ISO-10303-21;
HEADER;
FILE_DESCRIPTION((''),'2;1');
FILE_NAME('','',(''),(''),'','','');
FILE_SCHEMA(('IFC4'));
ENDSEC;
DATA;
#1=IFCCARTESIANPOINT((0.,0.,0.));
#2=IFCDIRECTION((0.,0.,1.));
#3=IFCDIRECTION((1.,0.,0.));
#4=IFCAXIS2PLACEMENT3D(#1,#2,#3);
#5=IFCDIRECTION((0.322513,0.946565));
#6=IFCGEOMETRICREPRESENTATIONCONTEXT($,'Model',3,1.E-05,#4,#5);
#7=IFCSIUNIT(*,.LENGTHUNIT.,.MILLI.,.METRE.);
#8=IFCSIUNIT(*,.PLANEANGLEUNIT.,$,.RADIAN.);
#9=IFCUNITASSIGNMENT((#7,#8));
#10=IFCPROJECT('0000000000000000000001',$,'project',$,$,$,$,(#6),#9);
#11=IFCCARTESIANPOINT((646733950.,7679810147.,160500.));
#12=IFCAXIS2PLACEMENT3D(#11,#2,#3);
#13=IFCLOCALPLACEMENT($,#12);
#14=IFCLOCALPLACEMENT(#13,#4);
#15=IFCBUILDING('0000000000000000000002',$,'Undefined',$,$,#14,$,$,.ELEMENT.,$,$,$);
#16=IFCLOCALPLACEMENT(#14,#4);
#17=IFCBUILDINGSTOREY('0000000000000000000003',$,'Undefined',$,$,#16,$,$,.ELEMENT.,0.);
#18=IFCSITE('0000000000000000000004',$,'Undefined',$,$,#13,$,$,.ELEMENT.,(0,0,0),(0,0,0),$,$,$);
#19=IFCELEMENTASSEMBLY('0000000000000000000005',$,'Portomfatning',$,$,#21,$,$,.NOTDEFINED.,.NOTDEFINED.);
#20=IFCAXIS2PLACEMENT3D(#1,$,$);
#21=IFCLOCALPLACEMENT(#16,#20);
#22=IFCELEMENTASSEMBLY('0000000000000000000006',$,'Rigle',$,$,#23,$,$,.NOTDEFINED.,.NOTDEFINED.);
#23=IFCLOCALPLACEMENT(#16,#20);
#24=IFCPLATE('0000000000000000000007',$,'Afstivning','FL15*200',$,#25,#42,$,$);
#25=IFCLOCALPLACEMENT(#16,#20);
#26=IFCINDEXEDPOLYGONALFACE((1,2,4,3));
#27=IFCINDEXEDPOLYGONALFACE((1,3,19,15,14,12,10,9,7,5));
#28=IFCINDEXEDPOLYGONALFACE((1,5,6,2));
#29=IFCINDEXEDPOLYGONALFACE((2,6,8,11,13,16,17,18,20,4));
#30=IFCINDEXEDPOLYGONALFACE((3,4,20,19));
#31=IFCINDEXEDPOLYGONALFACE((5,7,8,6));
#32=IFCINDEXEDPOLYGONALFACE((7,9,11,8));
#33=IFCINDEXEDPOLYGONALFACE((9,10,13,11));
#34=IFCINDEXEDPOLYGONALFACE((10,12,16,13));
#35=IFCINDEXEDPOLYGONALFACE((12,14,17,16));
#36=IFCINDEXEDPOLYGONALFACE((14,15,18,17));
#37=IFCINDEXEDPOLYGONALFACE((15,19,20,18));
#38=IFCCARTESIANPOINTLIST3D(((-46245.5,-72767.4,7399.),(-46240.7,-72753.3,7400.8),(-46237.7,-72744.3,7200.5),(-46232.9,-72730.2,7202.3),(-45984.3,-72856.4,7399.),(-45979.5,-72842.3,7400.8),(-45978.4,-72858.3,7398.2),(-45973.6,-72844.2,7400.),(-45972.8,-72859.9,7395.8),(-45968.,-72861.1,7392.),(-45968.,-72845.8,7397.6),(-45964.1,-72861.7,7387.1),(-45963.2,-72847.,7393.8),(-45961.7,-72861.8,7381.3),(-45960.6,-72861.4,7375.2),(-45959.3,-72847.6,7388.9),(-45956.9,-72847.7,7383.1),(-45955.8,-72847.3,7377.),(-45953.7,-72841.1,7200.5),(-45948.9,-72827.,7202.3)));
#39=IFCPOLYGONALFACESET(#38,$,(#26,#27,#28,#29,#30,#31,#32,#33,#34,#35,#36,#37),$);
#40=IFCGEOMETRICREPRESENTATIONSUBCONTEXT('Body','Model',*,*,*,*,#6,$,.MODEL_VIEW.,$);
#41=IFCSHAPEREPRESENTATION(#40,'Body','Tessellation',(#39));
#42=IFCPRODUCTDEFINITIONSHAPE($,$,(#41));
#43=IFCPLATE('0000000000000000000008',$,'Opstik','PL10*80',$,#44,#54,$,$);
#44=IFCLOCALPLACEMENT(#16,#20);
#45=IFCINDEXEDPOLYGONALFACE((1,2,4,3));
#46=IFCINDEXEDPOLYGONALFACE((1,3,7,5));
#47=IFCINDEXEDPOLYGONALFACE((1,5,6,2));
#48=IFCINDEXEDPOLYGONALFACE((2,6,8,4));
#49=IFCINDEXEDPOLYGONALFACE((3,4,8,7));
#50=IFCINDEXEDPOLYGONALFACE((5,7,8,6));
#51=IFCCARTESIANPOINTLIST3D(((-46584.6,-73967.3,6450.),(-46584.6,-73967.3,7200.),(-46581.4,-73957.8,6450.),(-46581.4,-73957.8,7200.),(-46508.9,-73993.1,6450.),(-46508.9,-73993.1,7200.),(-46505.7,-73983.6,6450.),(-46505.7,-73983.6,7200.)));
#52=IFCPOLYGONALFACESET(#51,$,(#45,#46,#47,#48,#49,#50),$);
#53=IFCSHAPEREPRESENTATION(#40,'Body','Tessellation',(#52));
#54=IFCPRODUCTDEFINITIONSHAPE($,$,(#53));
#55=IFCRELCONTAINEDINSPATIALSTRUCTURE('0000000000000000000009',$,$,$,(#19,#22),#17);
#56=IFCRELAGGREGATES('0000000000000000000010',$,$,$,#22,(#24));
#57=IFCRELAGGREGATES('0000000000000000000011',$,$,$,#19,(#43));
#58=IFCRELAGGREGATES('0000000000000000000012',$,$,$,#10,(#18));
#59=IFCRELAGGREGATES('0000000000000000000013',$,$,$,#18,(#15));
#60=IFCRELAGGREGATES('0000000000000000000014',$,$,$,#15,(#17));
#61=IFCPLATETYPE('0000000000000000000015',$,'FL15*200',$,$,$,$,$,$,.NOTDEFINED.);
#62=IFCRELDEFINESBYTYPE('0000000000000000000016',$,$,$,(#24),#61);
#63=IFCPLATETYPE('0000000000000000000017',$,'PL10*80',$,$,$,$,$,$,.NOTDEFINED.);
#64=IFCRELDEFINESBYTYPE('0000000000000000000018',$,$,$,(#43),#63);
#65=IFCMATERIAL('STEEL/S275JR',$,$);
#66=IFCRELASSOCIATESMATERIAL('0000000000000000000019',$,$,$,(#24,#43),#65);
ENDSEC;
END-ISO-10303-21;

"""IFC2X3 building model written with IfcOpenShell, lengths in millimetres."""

from ifc_helpers import new_model, si_unit, direction, frame, frame_2d, origin_with_axes, place, context, subcontext, project, spatial, polyline, circle_curve, parameter, trimmed, segment, composite_curve, outline, extrude, material, type_object, element, aggregate, save


model = new_model("IFC2X3")

# Units and contexts
model_context = context("Model", 3, precision=1e-05, world=origin_with_axes(), true_north=direction((0.322513, 0.946565)))
body_context = subcontext(model_context, "Body", "Model", "MODEL_VIEW")
ifc_project = project(units=[si_unit("LENGTHUNIT", "METRE", prefix="MILLI"), si_unit("PLANEANGLEUNIT", "RADIAN")], contexts=[model_context])

# Site, building, storey
site_placement = place(None, frame((646733950.0, 7679810147.0, 160500.0), z_axis=(0.0, 0.0, 1.0), x_axis=(1.0, 0.0, 0.0)))
site = spatial("IfcSite", under=ifc_project, at=site_placement, Name="Undefined", CompositionType="ELEMENT", RefLatitude=(0, 0, 0), RefLongitude=(0, 0, 0))
building_placement = place(site_placement, origin_with_axes())
building = spatial("IfcBuilding", under=site, at=building_placement, Name="Undefined", CompositionType="ELEMENT")
storey_placement = place(building_placement, origin_with_axes())
storey = spatial("IfcBuildingStorey", under=building, at=storey_placement, Name="Undefined", CompositionType="ELEMENT", Elevation=0.0)

# Element assembly
ifc_material_1 = material(Name="STEEL/S275JR")
assembly_1_placement = place(storey_placement, origin_with_axes())
assembly_1 = element("IfcElementAssembly", 1, at=assembly_1_placement, inside=storey, Name="Portomfatning", AssemblyPlace="NOTDEFINED", PredefinedType="NOTDEFINED")

# Element assembly, plate
assembly_2_placement = place(storey_placement, origin_with_axes())
assembly_2 = element("IfcElementAssembly", 2, at=assembly_2_placement, inside=storey, Name="Rigle", AssemblyPlace="NOTDEFINED", PredefinedType="NOTDEFINED")
plate_type_1 = type_object("IfcPlateType", Name="FL15*200", PredefinedType="NOTDEFINED")
plate_1_placement = place(assembly_2_placement, frame((-45951.3, -72834.0, 7201.4), z_axis=(0.320109, 0.93951, 0.121869), x_axis=(-0.946565, 0.322513, 0.0)))
plate_1 = element("IfcPlate", 3, at=plate_1_placement, type_object=plate_type_1, material=ifc_material_1, Name="Afstivning", Description="FL15*200", context=body_context, shape_type="SweptSolid", body=[
    extrude(outline(composite_curve([segment(polyline([(0.0, 0.0), (300.0, 0.0), (300.0, 200.0), (24.0, 200.0)]), True, "CONTINUOUS"), segment(trimmed(circle_curve(frame_2d((24.0, 176.0), x_axis=(0.0, 1.0)), 24.0), [parameter(0.0)], [parameter(1.570796)], True, "PARAMETER"), True, "CONTINUOUS"), segment(polyline([(0.0, 176.0), (0.0, 0.0)]), True, "CONTINUOUS")], self_intersect=True)), frame((0.0, 0.0, -7.5), z_axis=(0.0, 0.0, 1.0), x_axis=(1.0, 0.0, 0.0)), (0.0, 0.0, 1.0), 15.0),
])
aggregate(assembly_2, [plate_1])

# Plate
plate_type_2 = type_object("IfcPlateType", Name="PL10*80", PredefinedType="NOTDEFINED")
plate_2_placement = place(assembly_1_placement, frame((-46507.3, -73988.4, 6450.0), z_axis=(-0.322513, -0.946565, 0.0), x_axis=(0.0, 0.0, 1.0)))
plate_2 = element("IfcPlate", 4, at=plate_2_placement, type_object=plate_type_2, material=ifc_material_1, Name="Opstik", Description="PL10*80", context=body_context, shape_type="SweptSolid", body=[
    extrude(outline(polyline([(0.0, 0.0), (750.0, 0.0), (750.0, 80.0), (750.0, 80.0), (0.0, 80.0), (0.0, 80.0), (0.0, 0.0)])), frame((0.0, 0.0, -5.0), z_axis=(0.0, 0.0, 1.0), x_axis=(1.0, 0.0, 0.0)), (0.0, 0.0, 1.0), 10.0),
])

aggregate(assembly_1, [plate_2])

save(model, "model.ifc")
